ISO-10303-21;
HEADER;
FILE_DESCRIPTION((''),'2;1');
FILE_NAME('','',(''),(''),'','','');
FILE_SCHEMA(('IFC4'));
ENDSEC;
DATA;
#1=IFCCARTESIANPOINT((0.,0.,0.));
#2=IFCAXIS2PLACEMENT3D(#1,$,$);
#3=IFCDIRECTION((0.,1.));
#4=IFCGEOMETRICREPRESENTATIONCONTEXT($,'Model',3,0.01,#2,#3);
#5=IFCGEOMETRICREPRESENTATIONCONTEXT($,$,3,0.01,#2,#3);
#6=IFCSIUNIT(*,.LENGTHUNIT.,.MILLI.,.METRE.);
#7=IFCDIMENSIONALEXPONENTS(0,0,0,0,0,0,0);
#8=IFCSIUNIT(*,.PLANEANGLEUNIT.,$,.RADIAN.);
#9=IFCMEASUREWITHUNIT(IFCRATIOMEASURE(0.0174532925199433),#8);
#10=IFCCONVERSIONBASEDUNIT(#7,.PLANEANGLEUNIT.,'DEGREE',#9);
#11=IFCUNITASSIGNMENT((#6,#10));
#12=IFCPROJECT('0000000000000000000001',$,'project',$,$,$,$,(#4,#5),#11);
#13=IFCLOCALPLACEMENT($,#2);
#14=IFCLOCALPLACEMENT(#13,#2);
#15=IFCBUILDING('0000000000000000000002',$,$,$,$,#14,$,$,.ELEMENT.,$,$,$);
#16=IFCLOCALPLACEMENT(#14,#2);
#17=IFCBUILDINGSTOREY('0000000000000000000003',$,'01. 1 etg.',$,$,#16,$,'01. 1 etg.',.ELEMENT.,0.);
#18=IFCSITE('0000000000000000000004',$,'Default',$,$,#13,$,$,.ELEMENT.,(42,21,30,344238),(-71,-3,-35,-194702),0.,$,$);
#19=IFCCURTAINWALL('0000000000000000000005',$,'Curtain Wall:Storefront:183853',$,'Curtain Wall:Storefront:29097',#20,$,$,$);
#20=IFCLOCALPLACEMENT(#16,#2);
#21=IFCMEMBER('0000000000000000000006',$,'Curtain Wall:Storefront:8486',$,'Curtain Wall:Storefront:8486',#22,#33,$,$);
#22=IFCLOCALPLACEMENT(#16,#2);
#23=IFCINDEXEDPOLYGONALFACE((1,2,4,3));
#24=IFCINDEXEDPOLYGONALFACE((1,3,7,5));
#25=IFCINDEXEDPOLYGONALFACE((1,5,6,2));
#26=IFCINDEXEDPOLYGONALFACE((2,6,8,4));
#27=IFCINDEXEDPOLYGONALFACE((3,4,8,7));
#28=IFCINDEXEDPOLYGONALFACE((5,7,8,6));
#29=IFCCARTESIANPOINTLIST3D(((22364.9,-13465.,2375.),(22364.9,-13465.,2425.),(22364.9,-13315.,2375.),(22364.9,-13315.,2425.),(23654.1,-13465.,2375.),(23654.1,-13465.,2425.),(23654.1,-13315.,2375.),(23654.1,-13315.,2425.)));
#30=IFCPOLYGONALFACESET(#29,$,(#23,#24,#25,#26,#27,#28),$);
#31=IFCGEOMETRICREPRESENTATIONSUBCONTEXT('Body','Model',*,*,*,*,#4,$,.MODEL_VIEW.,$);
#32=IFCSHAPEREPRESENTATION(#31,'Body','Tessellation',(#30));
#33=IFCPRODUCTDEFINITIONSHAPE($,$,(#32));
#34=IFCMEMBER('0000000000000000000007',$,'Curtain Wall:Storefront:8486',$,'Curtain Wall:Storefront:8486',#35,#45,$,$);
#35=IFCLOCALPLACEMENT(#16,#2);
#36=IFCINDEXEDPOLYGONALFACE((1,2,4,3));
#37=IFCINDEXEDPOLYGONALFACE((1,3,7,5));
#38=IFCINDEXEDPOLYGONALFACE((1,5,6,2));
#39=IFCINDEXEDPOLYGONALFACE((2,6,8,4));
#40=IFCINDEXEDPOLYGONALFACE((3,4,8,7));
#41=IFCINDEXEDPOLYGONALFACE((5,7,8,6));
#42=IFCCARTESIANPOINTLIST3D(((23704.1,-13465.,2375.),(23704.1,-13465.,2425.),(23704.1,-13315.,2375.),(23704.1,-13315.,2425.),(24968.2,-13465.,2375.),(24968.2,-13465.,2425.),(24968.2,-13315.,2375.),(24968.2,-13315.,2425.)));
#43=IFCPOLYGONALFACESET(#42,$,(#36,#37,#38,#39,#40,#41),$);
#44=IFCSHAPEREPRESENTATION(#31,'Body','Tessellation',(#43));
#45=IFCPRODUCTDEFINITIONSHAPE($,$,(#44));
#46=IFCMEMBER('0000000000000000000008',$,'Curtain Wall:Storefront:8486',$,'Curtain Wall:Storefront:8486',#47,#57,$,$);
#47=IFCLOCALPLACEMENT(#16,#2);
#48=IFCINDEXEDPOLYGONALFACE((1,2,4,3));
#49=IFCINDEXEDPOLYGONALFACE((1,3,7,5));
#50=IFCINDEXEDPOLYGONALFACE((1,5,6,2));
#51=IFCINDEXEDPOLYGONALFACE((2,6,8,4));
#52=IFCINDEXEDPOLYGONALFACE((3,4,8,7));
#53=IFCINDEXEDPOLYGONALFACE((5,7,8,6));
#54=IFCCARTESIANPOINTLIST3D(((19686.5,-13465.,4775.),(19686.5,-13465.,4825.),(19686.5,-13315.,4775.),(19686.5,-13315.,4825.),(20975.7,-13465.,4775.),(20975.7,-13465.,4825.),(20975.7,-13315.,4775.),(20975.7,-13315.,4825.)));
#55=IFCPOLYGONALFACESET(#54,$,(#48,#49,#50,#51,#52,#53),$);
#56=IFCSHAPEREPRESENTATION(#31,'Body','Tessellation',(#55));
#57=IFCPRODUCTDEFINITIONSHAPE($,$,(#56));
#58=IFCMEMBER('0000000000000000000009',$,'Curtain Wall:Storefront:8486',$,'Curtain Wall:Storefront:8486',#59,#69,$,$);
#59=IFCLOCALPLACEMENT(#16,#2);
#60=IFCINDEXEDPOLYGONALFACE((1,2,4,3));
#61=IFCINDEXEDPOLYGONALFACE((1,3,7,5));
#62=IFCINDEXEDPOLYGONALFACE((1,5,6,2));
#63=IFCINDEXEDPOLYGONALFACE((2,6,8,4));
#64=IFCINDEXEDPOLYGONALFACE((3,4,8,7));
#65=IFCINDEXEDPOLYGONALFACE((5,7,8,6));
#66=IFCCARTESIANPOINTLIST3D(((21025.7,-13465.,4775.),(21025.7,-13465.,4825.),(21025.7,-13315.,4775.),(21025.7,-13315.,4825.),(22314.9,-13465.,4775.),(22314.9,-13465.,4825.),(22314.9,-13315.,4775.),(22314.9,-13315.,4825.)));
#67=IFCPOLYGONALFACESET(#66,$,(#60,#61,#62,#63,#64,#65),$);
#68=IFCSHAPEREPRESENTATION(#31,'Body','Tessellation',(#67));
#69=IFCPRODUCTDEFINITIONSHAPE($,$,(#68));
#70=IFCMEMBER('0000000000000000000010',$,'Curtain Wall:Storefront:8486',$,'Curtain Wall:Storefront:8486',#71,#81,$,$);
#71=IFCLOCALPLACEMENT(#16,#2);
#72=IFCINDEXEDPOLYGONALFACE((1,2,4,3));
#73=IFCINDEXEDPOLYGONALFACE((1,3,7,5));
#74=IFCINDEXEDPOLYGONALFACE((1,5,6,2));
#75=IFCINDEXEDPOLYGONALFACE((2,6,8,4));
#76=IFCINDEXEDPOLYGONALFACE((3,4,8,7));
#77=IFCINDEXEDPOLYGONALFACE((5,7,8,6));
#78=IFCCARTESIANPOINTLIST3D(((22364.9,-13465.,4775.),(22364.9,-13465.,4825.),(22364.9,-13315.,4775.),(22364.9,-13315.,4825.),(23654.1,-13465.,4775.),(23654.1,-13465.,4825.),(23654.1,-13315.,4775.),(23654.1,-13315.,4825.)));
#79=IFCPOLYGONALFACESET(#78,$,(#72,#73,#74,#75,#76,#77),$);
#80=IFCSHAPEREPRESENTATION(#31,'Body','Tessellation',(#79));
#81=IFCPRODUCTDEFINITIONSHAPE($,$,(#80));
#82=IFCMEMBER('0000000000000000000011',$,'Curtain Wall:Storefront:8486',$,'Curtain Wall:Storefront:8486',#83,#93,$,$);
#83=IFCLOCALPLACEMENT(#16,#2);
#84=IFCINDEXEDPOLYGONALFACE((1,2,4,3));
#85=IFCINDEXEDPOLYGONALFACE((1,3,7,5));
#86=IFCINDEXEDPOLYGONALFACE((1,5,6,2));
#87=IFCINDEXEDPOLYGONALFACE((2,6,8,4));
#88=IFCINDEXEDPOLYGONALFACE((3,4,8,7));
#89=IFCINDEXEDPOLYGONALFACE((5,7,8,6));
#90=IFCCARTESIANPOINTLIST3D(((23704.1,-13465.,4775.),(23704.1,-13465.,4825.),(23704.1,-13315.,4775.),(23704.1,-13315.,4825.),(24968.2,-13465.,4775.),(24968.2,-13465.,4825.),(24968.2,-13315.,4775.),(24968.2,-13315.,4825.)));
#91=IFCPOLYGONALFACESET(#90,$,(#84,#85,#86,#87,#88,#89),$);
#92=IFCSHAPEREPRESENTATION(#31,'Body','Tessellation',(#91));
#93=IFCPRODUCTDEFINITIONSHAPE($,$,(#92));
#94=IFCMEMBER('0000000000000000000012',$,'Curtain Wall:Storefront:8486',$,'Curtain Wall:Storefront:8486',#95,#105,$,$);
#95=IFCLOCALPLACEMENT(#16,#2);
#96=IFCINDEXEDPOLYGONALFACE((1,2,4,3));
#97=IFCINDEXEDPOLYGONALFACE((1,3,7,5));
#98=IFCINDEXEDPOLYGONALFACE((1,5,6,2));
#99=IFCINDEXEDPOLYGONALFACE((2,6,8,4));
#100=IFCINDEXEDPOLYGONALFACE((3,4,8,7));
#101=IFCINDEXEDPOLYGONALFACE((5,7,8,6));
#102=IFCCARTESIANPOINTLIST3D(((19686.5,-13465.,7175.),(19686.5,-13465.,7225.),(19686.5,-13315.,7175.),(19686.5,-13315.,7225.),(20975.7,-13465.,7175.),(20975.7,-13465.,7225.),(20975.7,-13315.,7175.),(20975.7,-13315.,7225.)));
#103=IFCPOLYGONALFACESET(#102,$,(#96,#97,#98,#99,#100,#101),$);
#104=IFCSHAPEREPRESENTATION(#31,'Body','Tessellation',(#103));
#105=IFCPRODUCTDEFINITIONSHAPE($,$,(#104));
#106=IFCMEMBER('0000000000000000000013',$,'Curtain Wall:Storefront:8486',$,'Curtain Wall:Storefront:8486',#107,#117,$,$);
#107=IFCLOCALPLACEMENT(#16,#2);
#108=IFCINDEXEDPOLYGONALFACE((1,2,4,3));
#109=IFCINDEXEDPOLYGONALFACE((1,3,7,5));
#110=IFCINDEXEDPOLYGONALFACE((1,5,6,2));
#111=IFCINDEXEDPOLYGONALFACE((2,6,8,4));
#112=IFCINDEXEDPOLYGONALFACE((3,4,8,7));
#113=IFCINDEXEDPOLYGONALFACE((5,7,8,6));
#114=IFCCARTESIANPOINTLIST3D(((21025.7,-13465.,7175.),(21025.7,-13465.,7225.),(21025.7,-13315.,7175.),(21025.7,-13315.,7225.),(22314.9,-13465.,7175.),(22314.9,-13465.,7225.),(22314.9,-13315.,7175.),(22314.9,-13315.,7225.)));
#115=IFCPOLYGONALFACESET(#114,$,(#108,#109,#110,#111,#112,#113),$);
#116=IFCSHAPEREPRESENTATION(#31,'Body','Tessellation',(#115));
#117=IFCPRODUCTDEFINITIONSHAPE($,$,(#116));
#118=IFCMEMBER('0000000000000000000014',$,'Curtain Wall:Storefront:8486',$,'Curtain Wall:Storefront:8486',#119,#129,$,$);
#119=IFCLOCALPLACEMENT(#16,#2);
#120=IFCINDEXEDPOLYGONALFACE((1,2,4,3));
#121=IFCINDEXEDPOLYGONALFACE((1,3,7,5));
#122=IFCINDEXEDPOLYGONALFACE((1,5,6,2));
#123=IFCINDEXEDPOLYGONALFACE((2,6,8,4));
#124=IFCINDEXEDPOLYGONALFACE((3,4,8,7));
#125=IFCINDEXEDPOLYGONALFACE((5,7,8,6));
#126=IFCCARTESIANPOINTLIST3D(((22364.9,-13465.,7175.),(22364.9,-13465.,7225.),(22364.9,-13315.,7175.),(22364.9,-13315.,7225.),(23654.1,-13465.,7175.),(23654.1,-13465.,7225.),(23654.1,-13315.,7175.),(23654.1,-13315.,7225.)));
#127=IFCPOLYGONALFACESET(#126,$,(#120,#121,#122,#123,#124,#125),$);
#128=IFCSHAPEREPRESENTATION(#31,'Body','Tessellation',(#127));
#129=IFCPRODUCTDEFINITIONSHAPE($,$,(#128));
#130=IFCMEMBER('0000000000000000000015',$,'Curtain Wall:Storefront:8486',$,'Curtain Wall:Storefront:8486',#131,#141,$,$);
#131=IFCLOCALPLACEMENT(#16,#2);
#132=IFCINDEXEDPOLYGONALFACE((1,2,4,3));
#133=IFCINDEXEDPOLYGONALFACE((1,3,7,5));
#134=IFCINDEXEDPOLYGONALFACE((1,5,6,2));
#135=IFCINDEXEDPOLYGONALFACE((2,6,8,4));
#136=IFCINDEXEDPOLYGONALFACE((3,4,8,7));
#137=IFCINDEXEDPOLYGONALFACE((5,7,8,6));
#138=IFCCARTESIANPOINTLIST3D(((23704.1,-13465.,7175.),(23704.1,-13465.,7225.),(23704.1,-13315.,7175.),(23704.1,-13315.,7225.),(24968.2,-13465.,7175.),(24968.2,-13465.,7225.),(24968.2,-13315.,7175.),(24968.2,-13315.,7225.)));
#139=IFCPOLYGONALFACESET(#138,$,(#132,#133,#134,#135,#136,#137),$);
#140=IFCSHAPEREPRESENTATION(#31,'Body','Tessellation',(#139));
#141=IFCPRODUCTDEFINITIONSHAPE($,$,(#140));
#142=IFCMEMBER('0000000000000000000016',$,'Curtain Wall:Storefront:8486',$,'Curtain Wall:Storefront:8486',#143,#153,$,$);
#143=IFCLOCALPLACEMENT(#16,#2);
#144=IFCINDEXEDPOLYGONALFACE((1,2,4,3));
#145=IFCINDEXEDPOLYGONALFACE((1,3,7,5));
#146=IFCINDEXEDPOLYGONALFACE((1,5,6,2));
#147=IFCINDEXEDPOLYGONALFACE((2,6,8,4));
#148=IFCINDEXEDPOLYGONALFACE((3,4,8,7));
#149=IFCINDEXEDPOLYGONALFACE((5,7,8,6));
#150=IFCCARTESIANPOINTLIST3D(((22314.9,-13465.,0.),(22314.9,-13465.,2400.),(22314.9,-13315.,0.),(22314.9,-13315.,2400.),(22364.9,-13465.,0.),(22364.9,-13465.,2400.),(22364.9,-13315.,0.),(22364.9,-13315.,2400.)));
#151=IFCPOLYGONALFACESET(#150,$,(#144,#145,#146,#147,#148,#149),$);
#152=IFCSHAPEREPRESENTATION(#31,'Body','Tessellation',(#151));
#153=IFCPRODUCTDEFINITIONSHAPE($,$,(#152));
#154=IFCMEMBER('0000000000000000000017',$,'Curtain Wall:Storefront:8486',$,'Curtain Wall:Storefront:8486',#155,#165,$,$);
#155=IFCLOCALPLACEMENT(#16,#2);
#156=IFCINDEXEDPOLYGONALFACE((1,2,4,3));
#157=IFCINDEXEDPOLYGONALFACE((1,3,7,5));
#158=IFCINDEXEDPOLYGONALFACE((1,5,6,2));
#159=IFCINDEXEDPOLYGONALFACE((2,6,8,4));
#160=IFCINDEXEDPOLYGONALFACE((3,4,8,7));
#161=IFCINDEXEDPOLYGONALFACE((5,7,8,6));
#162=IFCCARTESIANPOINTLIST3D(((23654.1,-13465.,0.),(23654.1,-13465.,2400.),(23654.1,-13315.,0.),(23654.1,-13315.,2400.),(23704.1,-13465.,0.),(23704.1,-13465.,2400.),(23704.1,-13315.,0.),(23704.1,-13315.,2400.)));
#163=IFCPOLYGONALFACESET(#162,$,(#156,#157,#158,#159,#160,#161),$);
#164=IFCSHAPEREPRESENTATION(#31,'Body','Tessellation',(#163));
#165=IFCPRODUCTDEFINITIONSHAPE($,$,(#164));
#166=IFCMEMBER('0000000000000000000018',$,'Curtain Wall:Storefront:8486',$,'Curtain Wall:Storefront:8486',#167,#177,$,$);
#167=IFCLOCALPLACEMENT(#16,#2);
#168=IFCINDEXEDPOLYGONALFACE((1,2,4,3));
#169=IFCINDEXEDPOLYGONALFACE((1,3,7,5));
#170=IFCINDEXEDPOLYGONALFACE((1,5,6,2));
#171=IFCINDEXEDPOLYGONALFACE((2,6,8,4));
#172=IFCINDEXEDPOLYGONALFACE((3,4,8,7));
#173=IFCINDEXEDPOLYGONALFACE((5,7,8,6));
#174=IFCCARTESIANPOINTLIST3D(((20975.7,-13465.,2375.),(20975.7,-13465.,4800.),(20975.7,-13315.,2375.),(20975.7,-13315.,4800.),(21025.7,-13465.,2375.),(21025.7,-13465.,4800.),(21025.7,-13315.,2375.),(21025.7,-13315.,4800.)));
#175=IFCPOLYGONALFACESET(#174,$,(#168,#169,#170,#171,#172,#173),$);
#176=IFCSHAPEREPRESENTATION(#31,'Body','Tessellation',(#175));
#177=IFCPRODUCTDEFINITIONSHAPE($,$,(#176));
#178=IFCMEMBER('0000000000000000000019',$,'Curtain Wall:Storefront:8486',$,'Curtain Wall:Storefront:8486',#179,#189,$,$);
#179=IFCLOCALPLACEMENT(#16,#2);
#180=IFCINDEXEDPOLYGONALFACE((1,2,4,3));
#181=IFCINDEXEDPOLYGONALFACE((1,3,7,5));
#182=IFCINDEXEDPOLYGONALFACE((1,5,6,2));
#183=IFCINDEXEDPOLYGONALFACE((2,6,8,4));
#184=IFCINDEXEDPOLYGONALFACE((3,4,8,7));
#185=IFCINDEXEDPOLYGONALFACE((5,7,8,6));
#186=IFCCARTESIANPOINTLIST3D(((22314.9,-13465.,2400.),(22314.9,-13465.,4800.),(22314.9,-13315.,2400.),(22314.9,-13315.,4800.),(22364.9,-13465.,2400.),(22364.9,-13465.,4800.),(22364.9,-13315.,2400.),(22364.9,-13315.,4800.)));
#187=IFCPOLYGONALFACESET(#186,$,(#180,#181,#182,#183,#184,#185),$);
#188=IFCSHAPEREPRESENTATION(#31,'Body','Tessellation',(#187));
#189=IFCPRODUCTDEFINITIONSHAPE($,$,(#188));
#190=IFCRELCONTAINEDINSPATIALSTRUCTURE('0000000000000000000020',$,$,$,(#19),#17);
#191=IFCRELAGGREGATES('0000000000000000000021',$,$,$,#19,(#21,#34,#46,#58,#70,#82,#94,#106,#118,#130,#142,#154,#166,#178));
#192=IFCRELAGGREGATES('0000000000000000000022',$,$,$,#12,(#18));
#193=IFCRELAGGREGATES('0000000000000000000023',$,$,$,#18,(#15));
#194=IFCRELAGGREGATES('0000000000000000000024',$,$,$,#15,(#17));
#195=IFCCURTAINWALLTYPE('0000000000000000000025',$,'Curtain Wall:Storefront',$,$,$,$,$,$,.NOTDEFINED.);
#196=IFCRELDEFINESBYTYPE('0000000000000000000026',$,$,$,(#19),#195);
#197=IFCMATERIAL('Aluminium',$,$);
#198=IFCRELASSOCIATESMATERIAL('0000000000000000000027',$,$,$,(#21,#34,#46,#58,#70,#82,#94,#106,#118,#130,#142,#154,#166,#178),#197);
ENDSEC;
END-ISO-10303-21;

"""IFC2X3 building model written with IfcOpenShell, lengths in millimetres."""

from ifc_helpers import new_model, entity, si_unit, converted_unit, direction, frame, frame_2d, origin, place, context, subcontext, project, spatial, rectangle, extrude, material, type_object, element, aggregate, save


model = new_model("IFC2X3")

# Units and contexts
model_context = context("Model", 3, precision=0.01, world=origin(), true_north=direction((0.0, 1.0)))
context_of_model = context(None, 3, precision=0.01, world=origin(), true_north=direction((0.0, 1.0)))
body_context = subcontext(model_context, "Body", "Model", "MODEL_VIEW")
ifc_project = project(units=[si_unit("LENGTHUNIT", "METRE", prefix="MILLI"), converted_unit("PLANEANGLEUNIT", "DEGREE", entity("IfcRatioMeasure", 0.0174532925199433), si_unit("PLANEANGLEUNIT", "RADIAN"), dimensions=[0, 0, 0, 0, 0, 0, 0])], contexts=[model_context, context_of_model])

# Site, building, storey
site_placement = place(None, origin())
site = spatial("IfcSite", under=ifc_project, at=site_placement, Name="Default", CompositionType="ELEMENT", RefLatitude=(42, 21, 30, 344238), RefLongitude=(-71, -3, -35, -194702), RefElevation=0.0)
building_placement = place(site_placement, origin())
building = spatial("IfcBuilding", under=site, at=building_placement, CompositionType="ELEMENT")
storey_placement = place(building_placement, origin())
storey = spatial("IfcBuildingStorey", under=building, at=storey_placement, Name="01. 1 etg.", LongName="01. 1 etg.", CompositionType="ELEMENT", Elevation=0.0)

# Curtain wall, members
curtain_wall_type = type_object("IfcCurtainWallType", Name="Curtain Wall:Storefront", PredefinedType="NOTDEFINED")
curtain_wall_placement = place(storey_placement, origin())
curtain_wall = element("IfcCurtainWall", 1, at=curtain_wall_placement, inside=storey, type_object=curtain_wall_type, Name="Curtain Wall:Storefront:183853", ObjectType="Curtain Wall:Storefront:29097")
ifc_material_1 = material(Name="Aluminium")
member_1_placement = place(curtain_wall_placement, frame((22364.9, -13465.0, 2375.0)))
member_1 = element("IfcMember", 2, at=member_1_placement, material=ifc_material_1, Name="Curtain Wall:Storefront:8486", ObjectType="Curtain Wall:Storefront:8486", context=body_context, shape_type="SweptSolid", body=[
    extrude(rectangle(XDim=1289.2, YDim=150.0, at=frame_2d((0.0, 0.0), x_axis=(1.0, 0.0))), frame((644.6, 75.0, 0.0), z_axis=(0.0, 0.0, 1.0), x_axis=(-1.0, 0.0, 0.0)), (0.0, 0.0, 1.0), 50.0),
])
member_2_placement = place(curtain_wall_placement, frame((23704.1, -13465.0, 2375.0)))
member_2 = element("IfcMember", 3, at=member_2_placement, material=ifc_material_1, Name="Curtain Wall:Storefront:8486", ObjectType="Curtain Wall:Storefront:8486", context=body_context, shape_type="SweptSolid", body=[
    extrude(rectangle(XDim=1264.2, YDim=150.0, at=frame_2d((0.0, 0.0), x_axis=(1.0, 0.0))), frame((632.1, 75.0, 0.0), z_axis=(0.0, 0.0, 1.0), x_axis=(-1.0, 0.0, 0.0)), (0.0, 0.0, 1.0), 50.0),
])
member_3_placement = place(curtain_wall_placement, frame((19686.5, -13465.0, 4775.0)))
member_3 = element("IfcMember", 4, at=member_3_placement, material=ifc_material_1, Name="Curtain Wall:Storefront:8486", ObjectType="Curtain Wall:Storefront:8486", context=body_context, shape_type="SweptSolid", body=[
    extrude(rectangle(XDim=1289.2, YDim=150.0, at=frame_2d((0.0, 0.0), x_axis=(1.0, 0.0))), frame((644.6, 75.0, 0.0), z_axis=(0.0, 0.0, 1.0), x_axis=(-1.0, 0.0, 0.0)), (0.0, 0.0, 1.0), 50.0),
])
member_4_placement = place(curtain_wall_placement, frame((21025.7, -13465.0, 4775.0)))
member_4 = element("IfcMember", 5, at=member_4_placement, material=ifc_material_1, Name="Curtain Wall:Storefront:8486", ObjectType="Curtain Wall:Storefront:8486", context=body_context, shape_type="SweptSolid", body=[
    extrude(rectangle(XDim=1289.2, YDim=150.0, at=frame_2d((0.0, 0.0), x_axis=(1.0, 0.0))), frame((644.6, 75.0, 0.0), z_axis=(0.0, 0.0, 1.0), x_axis=(-1.0, 0.0, 0.0)), (0.0, 0.0, 1.0), 50.0),
])
member_5_placement = place(curtain_wall_placement, frame((22364.9, -13465.0, 4775.0)))
member_5 = element("IfcMember", 6, at=member_5_placement, material=ifc_material_1, Name="Curtain Wall:Storefront:8486", ObjectType="Curtain Wall:Storefront:8486", context=body_context, shape_type="SweptSolid", body=[
    extrude(rectangle(XDim=1289.2, YDim=150.0, at=frame_2d((0.0, 0.0), x_axis=(1.0, 0.0))), frame((644.6, 75.0, 0.0), z_axis=(0.0, 0.0, 1.0), x_axis=(-1.0, 0.0, 0.0)), (0.0, 0.0, 1.0), 50.0),
])
member_6_placement = place(curtain_wall_placement, frame((23704.1, -13465.0, 4775.0)))
member_6 = element("IfcMember", 7, at=member_6_placement, material=ifc_material_1, Name="Curtain Wall:Storefront:8486", ObjectType="Curtain Wall:Storefront:8486", context=body_context, shape_type="SweptSolid", body=[
    extrude(rectangle(XDim=1264.2, YDim=150.0, at=frame_2d((0.0, 0.0), x_axis=(1.0, 0.0))), frame((632.1, 75.0, 0.0), z_axis=(0.0, 0.0, 1.0), x_axis=(-1.0, 0.0, 0.0)), (0.0, 0.0, 1.0), 50.0),
])
member_7_placement = place(curtain_wall_placement, frame((19686.5, -13465.0, 7175.0)))
member_7 = element("IfcMember", 8, at=member_7_placement, material=ifc_material_1, Name="Curtain Wall:Storefront:8486", ObjectType="Curtain Wall:Storefront:8486", context=body_context, shape_type="SweptSolid", body=[
    extrude(rectangle(XDim=1289.2, YDim=150.0, at=frame_2d((0.0, 0.0), x_axis=(1.0, 0.0))), frame((644.6, 75.0, 0.0), z_axis=(0.0, 0.0, 1.0), x_axis=(-1.0, 0.0, 0.0)), (0.0, 0.0, 1.0), 50.0),
])
member_8_placement = place(curtain_wall_placement, frame((21025.7, -13465.0, 7175.0)))
member_8 = element("IfcMember", 9, at=member_8_placement, material=ifc_material_1, Name="Curtain Wall:Storefront:8486", ObjectType="Curtain Wall:Storefront:8486", context=body_context, shape_type="SweptSolid", body=[
    extrude(rectangle(XDim=1289.2, YDim=150.0, at=frame_2d((0.0, 0.0), x_axis=(1.0, 0.0))), frame((644.6, 75.0, 0.0), z_axis=(0.0, 0.0, 1.0), x_axis=(-1.0, 0.0, 0.0)), (0.0, 0.0, 1.0), 50.0),
])
member_9_placement = place(curtain_wall_placement, frame((22364.9, -13465.0, 7175.0)))
member_9 = element("IfcMember", 10, at=member_9_placement, material=ifc_material_1, Name="Curtain Wall:Storefront:8486", ObjectType="Curtain Wall:Storefront:8486", context=body_context, shape_type="SweptSolid", body=[
    extrude(rectangle(XDim=1289.2, YDim=150.0, at=frame_2d((0.0, 0.0), x_axis=(1.0, 0.0))), frame((644.6, 75.0, 0.0), z_axis=(0.0, 0.0, 1.0), x_axis=(-1.0, 0.0, 0.0)), (0.0, 0.0, 1.0), 50.0),
])
member_10_placement = place(curtain_wall_placement, frame((23704.1, -13465.0, 7175.0)))
member_10 = element("IfcMember", 11, at=member_10_placement, material=ifc_material_1, Name="Curtain Wall:Storefront:8486", ObjectType="Curtain Wall:Storefront:8486", context=body_context, shape_type="SweptSolid", body=[
    extrude(rectangle(XDim=1264.2, YDim=150.0, at=frame_2d((0.0, 0.0), x_axis=(1.0, 0.0))), frame((632.1, 75.0, 0.0), z_axis=(0.0, 0.0, 1.0), x_axis=(-1.0, 0.0, 0.0)), (0.0, 0.0, 1.0), 50.0),
])
member_11_placement = place(curtain_wall_placement, frame((22314.9, -13465.0, 0.0)))
member_11 = element("IfcMember", 12, at=member_11_placement, material=ifc_material_1, Name="Curtain Wall:Storefront:8486", ObjectType="Curtain Wall:Storefront:8486", context=body_context, shape_type="SweptSolid", body=[
    extrude(rectangle(XDim=150.0, YDim=50.0, at=frame_2d((0.0, 0.0), x_axis=(1.0, 0.0))), frame((25.0, 75.0, 0.0), z_axis=(0.0, 0.0, 1.0), x_axis=(0.0, 1.0, 0.0)), (0.0, 0.0, 1.0), 2400.0),
])
member_12_placement = place(curtain_wall_placement, frame((23654.1, -13465.0, 0.0)))
member_12 = element("IfcMember", 13, at=member_12_placement, material=ifc_material_1, Name="Curtain Wall:Storefront:8486", ObjectType="Curtain Wall:Storefront:8486", context=body_context, shape_type="SweptSolid", body=[
    extrude(rectangle(XDim=150.0, YDim=50.0, at=frame_2d((0.0, 0.0), x_axis=(1.0, 0.0))), frame((25.0, 75.0, 0.0), z_axis=(0.0, 0.0, 1.0), x_axis=(0.0, 1.0, 0.0)), (0.0, 0.0, 1.0), 2400.0),
])
member_13_placement = place(curtain_wall_placement, frame((20975.7, -13465.0, 2375.0)))
member_13 = element("IfcMember", 14, at=member_13_placement, material=ifc_material_1, Name="Curtain Wall:Storefront:8486", ObjectType="Curtain Wall:Storefront:8486", context=body_context, shape_type="SweptSolid", body=[
    extrude(rectangle(XDim=150.0, YDim=50.0, at=frame_2d((0.0, 0.0), x_axis=(1.0, 0.0))), frame((25.0, 75.0, 0.0), z_axis=(0.0, 0.0, 1.0), x_axis=(0.0, 1.0, 0.0)), (0.0, 0.0, 1.0), 2425.0),
])
member_14_placement = place(curtain_wall_placement, frame((22314.9, -13465.0, 2400.0)))
member_14 = element("IfcMember", 15, at=member_14_placement, material=ifc_material_1, Name="Curtain Wall:Storefront:8486", ObjectType="Curtain Wall:Storefront:8486", context=body_context, shape_type="SweptSolid", body=[
    extrude(rectangle(XDim=150.0, YDim=50.0, at=frame_2d((0.0, 0.0), x_axis=(1.0, 0.0))), frame((25.0, 75.0, 0.0), z_axis=(0.0, 0.0, 1.0), x_axis=(0.0, 1.0, 0.0)), (0.0, 0.0, 1.0), 2400.0),
])
aggregate(curtain_wall, [member_1, member_2, member_3, member_4, member_5, member_6, member_7, member_8, member_9, member_10, member_11, member_12, member_13, member_14])

save(model, "model.ifc")
